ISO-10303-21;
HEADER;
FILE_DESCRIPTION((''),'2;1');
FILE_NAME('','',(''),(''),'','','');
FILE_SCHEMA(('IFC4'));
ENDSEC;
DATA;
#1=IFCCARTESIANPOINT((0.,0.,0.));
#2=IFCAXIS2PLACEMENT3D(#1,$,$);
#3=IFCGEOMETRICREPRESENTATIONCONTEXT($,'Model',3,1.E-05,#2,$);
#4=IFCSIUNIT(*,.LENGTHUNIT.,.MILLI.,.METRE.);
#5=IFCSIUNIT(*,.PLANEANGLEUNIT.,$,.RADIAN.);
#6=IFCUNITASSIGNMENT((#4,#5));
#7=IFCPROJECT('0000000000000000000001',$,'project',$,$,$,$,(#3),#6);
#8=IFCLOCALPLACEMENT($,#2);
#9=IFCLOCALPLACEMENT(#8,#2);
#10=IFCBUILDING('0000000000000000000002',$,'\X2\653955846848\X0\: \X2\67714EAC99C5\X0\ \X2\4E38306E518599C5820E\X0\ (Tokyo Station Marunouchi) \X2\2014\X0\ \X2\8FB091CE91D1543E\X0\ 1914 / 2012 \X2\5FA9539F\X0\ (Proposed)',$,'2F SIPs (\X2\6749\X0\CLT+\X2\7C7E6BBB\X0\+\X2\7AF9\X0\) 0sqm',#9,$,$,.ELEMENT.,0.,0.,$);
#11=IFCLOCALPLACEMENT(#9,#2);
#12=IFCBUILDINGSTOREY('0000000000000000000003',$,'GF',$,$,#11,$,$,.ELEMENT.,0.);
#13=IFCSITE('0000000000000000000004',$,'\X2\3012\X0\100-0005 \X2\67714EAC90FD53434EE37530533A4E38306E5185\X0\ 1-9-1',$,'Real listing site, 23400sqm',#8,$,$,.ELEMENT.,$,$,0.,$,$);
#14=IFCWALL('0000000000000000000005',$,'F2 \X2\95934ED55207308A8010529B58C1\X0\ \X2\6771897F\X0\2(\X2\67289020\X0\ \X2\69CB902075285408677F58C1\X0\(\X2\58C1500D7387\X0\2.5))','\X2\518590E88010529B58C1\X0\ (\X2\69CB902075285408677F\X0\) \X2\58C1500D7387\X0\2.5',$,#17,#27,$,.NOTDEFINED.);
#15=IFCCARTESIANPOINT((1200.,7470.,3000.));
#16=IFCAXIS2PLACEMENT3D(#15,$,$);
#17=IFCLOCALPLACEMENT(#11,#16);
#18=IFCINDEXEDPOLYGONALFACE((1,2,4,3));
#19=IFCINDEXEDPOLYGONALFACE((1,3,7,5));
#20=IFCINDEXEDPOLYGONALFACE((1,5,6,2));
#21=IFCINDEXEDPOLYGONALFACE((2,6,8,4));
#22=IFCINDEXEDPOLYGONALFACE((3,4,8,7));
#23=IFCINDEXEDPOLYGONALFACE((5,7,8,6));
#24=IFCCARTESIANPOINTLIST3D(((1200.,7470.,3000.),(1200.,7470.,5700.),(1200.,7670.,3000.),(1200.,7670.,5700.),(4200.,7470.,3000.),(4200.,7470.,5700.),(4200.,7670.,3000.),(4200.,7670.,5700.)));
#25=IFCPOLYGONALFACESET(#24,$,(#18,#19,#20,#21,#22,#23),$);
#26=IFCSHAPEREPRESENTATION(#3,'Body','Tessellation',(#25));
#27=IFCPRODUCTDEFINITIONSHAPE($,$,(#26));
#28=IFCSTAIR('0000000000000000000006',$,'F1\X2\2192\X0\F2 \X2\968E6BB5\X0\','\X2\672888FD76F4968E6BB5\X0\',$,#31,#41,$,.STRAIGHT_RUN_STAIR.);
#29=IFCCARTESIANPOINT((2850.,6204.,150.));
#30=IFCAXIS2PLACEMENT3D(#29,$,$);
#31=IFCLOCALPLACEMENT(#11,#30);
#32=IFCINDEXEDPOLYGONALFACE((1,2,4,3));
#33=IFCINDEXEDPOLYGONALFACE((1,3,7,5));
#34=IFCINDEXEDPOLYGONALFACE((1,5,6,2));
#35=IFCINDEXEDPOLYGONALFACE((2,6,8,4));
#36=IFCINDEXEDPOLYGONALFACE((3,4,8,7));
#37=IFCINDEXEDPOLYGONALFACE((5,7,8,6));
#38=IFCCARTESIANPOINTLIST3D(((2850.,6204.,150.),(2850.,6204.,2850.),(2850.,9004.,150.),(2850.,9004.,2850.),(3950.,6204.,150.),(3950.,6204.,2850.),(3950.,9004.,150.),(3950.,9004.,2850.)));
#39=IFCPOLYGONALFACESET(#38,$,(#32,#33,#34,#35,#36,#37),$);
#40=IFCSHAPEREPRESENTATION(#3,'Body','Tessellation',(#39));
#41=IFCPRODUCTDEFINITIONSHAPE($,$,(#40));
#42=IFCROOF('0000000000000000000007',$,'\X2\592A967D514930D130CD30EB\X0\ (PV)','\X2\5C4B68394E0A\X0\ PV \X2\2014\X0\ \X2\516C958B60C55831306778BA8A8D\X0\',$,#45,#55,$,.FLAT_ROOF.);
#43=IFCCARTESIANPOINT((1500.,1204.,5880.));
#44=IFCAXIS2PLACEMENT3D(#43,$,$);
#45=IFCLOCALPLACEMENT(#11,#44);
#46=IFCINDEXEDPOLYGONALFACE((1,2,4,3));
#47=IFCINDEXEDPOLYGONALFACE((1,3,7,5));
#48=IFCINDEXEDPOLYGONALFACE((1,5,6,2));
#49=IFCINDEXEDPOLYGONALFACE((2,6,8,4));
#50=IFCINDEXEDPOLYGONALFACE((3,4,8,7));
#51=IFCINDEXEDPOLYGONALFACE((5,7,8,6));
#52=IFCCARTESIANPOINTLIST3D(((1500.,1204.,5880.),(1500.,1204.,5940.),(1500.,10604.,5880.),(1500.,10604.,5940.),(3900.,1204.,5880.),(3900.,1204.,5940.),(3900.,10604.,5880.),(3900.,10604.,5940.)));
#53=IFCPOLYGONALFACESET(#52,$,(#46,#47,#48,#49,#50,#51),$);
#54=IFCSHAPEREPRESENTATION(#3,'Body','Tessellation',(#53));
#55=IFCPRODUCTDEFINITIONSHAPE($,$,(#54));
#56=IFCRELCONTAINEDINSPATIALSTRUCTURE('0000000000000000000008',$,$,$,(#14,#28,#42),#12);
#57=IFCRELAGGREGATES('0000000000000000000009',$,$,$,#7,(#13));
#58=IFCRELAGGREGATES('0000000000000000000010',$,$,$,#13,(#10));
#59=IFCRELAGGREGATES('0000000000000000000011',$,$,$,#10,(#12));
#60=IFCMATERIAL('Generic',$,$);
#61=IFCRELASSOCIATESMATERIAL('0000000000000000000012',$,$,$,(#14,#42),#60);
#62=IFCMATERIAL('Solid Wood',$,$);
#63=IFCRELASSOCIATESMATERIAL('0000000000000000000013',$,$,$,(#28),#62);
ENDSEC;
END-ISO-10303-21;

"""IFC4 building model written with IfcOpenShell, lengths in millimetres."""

from ifc_helpers import new_model, si_unit, frame, frame_2d, origin, place, context, project, spatial, rectangle, extrude, material, element, save


model = new_model("IFC4")

# Units and contexts
model_context = context("Model", 3, precision=1e-05, world=origin())
ifc_project = project(units=[si_unit("LENGTHUNIT", "METRE", prefix="MILLI"), si_unit("PLANEANGLEUNIT", "RADIAN")], contexts=[model_context])

# Site, building, storey
site_placement = place(None, origin())
site = spatial("IfcSite", under=ifc_project, at=site_placement, Name="〒100-0005 東京都千代田区丸の内 1-9-1", ObjectType="Real listing site, 23400sqm", CompositionType="ELEMENT", RefElevation=0.0)
building_placement = place(site_placement, origin())
building = spatial("IfcBuilding", under=site, at=building_placement, Name="改善案: 東京駅 丸の内駅舎 (Tokyo Station Marunouchi) — 辰野金吾 1914 / 2012 復原 (Proposed)", ObjectType="2F SIPs (杉CLT+籾殻+竹) 0sqm", CompositionType="ELEMENT", ElevationOfRefHeight=0.0, ElevationOfTerrain=0.0)
storey_placement = place(building_placement, origin())
storey = spatial("IfcBuildingStorey", under=building, at=storey_placement, Name="GF", CompositionType="ELEMENT", Elevation=0.0)

# Shared definitions
ifc_material_1 = material(Name="Generic")

# Wall
wall_1_placement = place(storey_placement, frame((1200.0, 7470.0, 3000.0)))
element("IfcWall", 1, at=wall_1_placement, inside=storey, material=ifc_material_1, Name="F2 間仕切り耐力壁 東西2(木造 構造用合板壁(壁倍率2.5))", Description="内部耐力壁 (構造用合板) 壁倍率2.5", PredefinedType="NOTDEFINED", context=model_context, shape_type="SweptSolid", body=[
    extrude(rectangle(XDim=3000.0, YDim=200.0, at=frame_2d((1500.0, 100.0))), frame((1200.0, 7470.0, 3000.0)), (0.0, 0.0, 1.0), 2700.0),
])

# Stair
ifc_material_2 = material(Name="Solid Wood")
stair_placement = place(storey_placement, frame((2850.0, 6204.0, 150.0)))
element("IfcStair", 2, at=stair_placement, inside=storey, material=ifc_material_2, Name="F1→F2 階段", Description="木製直階段", PredefinedType="STRAIGHT_RUN_STAIR", context=model_context, shape_type="SweptSolid", body=[
    extrude(rectangle(XDim=1100.0, YDim=2800.0, at=frame_2d((550.0, 1400.0))), frame((2850.0, 6204.0, 150.0)), (0.0, 0.0, 1.0), 2700.0),
])

# Roof
roof_placement = place(storey_placement, frame((1500.0, 1204.0, 5880.0)))
element("IfcRoof", 3, at=roof_placement, inside=storey, material=ifc_material_1, Name="太陽光パネル (PV)", Description="屋根上 PV — 公開情報で確認", PredefinedType="FLAT_ROOF", context=model_context, shape_type="SweptSolid", body=[
    extrude(rectangle(XDim=2400.0, YDim=9400.0, at=frame_2d((1200.0, 4700.0))), frame((1500.0, 1204.0, 5880.0)), (0.0, 0.0, 1.0), 60.0),
])

save(model, "model.ifc")
